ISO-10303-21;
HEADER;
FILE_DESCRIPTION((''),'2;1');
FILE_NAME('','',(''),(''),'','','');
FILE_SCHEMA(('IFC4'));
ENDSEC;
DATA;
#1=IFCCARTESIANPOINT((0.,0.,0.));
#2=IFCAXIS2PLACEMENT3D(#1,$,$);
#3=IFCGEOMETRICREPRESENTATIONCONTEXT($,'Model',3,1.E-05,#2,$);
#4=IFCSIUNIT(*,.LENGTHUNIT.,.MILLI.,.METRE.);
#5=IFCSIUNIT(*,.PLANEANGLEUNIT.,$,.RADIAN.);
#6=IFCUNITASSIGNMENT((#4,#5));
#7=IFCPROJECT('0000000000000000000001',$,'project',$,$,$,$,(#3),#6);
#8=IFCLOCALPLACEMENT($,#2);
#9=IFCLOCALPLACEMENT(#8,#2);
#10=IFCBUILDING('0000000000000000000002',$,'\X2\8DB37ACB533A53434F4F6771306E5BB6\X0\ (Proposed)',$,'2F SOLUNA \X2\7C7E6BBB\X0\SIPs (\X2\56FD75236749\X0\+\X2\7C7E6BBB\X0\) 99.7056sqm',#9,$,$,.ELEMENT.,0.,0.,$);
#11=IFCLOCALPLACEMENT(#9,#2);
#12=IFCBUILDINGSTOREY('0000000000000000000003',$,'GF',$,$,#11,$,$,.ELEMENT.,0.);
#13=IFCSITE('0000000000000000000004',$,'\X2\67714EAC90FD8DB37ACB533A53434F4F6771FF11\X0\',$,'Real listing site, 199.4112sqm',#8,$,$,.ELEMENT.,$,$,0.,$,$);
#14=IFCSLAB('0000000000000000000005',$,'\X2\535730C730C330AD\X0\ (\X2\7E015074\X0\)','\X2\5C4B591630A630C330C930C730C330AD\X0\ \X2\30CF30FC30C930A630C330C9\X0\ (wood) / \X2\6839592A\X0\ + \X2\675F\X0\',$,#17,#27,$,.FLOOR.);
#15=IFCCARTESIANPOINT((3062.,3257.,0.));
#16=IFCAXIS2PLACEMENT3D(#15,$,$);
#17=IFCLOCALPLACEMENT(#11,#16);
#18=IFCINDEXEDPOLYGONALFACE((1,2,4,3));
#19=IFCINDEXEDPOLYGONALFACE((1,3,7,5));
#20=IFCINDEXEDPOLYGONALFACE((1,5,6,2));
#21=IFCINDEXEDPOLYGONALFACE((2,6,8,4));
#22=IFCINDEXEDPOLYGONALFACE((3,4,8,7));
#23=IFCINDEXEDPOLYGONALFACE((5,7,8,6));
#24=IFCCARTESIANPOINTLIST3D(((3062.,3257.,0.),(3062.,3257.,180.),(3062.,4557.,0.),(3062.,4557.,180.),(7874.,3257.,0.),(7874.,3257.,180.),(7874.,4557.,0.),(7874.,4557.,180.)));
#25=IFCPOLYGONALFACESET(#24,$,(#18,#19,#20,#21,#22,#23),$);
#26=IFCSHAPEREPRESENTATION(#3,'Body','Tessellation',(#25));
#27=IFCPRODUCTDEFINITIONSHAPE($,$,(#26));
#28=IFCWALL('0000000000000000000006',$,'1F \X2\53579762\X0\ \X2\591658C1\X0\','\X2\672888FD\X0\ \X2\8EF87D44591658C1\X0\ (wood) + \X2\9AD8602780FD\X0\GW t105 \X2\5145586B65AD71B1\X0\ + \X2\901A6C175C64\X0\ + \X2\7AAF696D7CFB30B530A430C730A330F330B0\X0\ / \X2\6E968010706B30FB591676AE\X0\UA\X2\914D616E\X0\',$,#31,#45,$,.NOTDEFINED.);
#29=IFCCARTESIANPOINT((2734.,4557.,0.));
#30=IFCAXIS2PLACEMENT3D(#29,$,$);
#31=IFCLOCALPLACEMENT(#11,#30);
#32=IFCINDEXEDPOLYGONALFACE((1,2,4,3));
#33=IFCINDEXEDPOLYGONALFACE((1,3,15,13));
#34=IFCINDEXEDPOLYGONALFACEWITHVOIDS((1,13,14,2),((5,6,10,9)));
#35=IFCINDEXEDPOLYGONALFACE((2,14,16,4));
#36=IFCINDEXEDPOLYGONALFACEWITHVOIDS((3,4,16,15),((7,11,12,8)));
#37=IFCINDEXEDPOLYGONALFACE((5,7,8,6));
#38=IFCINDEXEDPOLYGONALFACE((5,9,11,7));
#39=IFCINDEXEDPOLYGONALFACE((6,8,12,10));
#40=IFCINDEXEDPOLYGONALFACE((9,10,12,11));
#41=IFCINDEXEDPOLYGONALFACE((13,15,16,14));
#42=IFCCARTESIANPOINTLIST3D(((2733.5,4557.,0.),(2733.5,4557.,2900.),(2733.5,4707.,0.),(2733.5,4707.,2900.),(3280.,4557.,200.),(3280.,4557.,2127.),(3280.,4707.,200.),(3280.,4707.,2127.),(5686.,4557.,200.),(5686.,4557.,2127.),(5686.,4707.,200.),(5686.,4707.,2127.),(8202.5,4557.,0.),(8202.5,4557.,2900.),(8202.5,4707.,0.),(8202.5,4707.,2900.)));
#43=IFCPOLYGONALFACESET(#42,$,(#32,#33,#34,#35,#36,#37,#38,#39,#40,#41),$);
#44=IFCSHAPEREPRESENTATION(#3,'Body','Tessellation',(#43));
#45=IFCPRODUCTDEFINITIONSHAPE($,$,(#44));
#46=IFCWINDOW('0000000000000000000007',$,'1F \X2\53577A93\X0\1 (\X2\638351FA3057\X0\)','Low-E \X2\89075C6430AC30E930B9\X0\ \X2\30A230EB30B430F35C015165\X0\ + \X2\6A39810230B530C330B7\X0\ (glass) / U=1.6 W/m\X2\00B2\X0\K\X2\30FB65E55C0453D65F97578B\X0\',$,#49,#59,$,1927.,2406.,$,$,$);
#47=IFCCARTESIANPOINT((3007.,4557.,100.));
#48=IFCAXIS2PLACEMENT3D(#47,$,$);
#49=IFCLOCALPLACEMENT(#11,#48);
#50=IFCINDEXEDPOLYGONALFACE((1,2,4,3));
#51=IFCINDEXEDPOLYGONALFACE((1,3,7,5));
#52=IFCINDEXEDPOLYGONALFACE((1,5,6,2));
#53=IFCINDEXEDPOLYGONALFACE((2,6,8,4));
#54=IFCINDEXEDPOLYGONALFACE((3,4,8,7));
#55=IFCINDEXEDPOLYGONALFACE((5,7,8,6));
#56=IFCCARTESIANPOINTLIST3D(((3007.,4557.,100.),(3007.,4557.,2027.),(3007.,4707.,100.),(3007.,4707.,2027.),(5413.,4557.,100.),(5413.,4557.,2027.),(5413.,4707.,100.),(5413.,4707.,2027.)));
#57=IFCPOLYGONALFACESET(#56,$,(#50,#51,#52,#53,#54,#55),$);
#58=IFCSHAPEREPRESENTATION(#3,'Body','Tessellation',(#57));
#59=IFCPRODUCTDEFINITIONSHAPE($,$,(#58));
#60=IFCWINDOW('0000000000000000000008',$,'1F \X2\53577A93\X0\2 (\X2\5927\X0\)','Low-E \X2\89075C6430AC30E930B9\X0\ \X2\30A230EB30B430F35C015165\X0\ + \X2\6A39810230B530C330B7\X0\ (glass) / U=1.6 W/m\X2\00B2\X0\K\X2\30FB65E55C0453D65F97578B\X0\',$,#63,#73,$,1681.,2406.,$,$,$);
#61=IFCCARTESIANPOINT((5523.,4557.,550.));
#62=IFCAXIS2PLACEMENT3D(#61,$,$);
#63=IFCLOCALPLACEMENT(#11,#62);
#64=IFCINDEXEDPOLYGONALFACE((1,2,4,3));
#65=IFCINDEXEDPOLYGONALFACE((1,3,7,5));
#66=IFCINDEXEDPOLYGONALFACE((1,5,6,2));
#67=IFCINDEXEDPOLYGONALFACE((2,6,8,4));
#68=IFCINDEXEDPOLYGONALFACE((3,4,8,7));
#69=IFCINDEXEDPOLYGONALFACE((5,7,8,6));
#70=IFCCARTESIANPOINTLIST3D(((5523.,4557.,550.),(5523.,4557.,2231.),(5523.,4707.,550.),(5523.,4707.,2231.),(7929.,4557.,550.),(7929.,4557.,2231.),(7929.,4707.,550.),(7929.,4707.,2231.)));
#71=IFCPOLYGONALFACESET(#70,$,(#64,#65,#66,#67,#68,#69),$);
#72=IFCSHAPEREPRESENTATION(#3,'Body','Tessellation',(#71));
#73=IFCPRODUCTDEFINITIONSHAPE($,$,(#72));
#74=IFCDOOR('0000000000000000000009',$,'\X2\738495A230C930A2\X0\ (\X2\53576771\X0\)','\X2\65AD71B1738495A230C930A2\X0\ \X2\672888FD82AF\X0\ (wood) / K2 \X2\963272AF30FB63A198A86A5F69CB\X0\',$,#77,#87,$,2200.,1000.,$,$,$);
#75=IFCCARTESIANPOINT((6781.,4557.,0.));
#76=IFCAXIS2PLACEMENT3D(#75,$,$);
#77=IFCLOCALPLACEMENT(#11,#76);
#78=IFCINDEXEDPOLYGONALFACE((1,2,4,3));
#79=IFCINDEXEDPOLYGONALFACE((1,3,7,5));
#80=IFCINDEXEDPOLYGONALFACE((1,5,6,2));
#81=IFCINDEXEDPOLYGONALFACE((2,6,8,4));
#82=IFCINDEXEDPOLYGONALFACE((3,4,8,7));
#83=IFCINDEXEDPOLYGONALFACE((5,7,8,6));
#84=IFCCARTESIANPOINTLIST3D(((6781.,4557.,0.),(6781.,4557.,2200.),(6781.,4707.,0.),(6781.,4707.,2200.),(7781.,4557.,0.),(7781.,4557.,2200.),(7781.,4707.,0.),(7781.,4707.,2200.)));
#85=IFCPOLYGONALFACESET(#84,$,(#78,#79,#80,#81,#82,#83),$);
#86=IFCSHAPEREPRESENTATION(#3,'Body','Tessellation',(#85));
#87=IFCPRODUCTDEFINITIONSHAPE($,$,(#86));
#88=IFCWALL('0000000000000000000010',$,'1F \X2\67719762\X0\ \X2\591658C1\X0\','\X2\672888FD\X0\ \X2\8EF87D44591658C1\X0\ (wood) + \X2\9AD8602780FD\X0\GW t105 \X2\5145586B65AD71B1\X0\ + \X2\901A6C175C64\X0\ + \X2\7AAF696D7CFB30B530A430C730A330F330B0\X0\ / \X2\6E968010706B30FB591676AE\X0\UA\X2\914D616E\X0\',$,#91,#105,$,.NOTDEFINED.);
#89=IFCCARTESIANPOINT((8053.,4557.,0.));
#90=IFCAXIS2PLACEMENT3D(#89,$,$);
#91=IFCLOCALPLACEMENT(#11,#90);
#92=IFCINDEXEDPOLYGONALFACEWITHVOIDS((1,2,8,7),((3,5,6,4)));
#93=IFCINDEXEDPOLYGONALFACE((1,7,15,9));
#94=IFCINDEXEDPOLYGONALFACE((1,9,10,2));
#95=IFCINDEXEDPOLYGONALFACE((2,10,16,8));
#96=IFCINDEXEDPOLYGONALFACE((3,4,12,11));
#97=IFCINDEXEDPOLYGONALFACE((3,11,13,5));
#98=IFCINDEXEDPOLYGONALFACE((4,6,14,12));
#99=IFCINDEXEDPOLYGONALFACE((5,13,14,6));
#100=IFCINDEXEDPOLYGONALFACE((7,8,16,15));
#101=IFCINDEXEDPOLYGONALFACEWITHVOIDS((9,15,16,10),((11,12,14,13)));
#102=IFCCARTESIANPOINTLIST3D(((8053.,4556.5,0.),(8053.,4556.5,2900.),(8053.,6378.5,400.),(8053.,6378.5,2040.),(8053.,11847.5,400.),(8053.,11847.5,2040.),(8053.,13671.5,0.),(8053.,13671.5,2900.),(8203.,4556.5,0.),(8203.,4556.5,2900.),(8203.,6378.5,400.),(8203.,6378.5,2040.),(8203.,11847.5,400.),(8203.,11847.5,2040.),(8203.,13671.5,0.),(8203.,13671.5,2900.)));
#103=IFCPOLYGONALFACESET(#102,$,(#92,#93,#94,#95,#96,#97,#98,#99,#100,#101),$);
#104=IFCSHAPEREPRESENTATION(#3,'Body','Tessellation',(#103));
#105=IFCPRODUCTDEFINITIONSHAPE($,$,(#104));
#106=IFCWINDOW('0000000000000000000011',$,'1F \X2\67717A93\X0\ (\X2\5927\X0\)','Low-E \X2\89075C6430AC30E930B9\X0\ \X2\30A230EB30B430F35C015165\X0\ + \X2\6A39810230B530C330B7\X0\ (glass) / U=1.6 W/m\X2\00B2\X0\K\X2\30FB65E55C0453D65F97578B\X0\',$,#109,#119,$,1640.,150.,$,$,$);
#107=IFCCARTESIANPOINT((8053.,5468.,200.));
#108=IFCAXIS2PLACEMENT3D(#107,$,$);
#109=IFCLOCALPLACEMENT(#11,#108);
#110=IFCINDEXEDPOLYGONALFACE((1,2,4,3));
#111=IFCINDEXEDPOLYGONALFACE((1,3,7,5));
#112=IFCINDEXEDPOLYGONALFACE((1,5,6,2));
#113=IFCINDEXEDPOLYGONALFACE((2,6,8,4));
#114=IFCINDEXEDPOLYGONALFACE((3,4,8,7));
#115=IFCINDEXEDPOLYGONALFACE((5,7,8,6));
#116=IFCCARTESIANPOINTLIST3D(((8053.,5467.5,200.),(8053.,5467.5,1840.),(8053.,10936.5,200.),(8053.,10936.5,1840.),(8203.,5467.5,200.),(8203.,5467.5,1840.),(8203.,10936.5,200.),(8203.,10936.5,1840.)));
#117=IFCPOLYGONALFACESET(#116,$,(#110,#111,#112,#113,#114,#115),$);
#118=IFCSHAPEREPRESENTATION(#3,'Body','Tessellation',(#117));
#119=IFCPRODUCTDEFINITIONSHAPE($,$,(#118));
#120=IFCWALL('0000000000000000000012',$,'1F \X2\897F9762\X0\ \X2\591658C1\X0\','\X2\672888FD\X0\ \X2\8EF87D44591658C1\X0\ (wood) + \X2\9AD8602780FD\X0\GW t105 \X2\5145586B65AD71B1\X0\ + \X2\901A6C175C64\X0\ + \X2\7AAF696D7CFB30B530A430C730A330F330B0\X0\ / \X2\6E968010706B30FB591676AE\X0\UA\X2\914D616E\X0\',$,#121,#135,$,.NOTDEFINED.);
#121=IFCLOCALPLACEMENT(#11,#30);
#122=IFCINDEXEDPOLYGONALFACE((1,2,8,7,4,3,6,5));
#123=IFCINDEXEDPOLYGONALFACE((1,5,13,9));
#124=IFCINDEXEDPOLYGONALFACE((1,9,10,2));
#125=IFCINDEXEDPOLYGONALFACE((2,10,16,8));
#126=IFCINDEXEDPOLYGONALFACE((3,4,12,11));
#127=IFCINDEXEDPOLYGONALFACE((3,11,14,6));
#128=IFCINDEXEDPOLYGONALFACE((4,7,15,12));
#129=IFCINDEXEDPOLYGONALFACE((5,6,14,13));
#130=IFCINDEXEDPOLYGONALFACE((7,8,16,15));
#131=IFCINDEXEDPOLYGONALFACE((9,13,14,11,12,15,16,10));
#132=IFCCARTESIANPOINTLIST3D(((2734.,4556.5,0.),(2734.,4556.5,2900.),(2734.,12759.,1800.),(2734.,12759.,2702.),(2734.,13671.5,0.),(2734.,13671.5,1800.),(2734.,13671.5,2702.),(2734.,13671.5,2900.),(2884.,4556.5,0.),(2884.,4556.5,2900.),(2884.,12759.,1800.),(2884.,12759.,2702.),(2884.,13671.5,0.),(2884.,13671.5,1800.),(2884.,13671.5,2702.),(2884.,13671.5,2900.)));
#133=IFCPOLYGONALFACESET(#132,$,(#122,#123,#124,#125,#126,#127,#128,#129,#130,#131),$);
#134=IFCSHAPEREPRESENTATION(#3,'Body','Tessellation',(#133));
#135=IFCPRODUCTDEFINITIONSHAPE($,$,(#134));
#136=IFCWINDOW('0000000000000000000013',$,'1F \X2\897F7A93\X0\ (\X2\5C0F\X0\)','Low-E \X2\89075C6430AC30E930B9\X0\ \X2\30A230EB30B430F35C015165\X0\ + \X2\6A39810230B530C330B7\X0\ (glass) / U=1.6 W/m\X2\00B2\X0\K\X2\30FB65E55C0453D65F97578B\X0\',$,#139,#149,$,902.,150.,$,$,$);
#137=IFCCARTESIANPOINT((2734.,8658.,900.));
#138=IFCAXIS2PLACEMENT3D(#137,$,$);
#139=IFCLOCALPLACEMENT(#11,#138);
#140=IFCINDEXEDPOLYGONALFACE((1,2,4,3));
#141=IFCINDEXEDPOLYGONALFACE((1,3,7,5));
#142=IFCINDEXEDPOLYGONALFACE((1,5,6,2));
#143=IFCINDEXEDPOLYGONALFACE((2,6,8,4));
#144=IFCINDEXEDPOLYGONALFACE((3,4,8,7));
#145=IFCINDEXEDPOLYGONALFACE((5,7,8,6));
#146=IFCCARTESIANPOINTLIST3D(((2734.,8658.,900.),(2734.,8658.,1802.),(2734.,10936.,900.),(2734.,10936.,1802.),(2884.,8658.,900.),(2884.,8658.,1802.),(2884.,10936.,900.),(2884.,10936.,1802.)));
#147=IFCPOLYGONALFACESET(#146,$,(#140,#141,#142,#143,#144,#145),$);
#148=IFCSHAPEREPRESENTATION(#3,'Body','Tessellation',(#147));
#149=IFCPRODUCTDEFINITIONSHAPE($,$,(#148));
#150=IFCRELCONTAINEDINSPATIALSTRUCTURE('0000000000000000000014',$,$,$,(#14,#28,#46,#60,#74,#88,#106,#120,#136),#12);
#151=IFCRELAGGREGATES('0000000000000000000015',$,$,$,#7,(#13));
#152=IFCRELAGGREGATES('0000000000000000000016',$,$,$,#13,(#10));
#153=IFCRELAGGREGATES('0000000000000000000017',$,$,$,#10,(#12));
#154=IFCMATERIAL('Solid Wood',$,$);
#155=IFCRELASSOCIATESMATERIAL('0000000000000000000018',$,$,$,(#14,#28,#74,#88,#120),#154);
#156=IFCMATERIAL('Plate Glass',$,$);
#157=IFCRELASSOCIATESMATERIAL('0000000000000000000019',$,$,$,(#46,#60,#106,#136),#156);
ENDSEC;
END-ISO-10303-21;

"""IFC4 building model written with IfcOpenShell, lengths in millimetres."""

from ifc_helpers import new_model, si_unit, frame, frame_2d, origin, place, context, project, spatial, rectangle, extrude, material, element, fill, save


model = new_model("IFC4")

# Units and contexts
model_context = context("Model", 3, precision=1e-05, world=origin())
ifc_project = project(units=[si_unit("LENGTHUNIT", "METRE", prefix="MILLI"), si_unit("PLANEANGLEUNIT", "RADIAN")], contexts=[model_context])

# Site, building, storey
site_placement = place(None, origin())
site = spatial("IfcSite", under=ifc_project, at=site_placement, Name="東京都足立区千住東１", ObjectType="Real listing site, 199.4112sqm", CompositionType="ELEMENT", RefElevation=0.0)
building_placement = place(site_placement, origin())
building = spatial("IfcBuilding", under=site, at=building_placement, Name="足立区千住東の家 (Proposed)", ObjectType="2F SOLUNA 籾殻SIPs (国産杉+籾殻) 99.7056sqm", CompositionType="ELEMENT", ElevationOfRefHeight=0.0, ElevationOfTerrain=0.0)
storey_placement = place(building_placement, origin())
storey = spatial("IfcBuildingStorey", under=building, at=storey_placement, Name="GF", CompositionType="ELEMENT", Elevation=0.0)

# Slab
ifc_material_1 = material(Name="Solid Wood")
slab_1_placement = place(storey_placement, frame((3062.0, 3257.0, 0.0)))
element("IfcSlab", 1, at=slab_1_placement, inside=storey, material=ifc_material_1, Name="南デッキ (縁側)", Description="屋外ウッドデッキ ハードウッド (wood) / 根太 + 束", PredefinedType="FLOOR", context=model_context, shape_type="SweptSolid", body=[
    extrude(rectangle(XDim=4812.0, YDim=1300.0, at=frame_2d((2406.0, 650.0))), frame((3062.0, 3257.0, 0.0)), (0.0, 0.0, 1.0), 180.0),
])

# Wall, openings, windows, door
wall_1_placement = place(storey_placement, frame((2734.0, 4557.0, 0.0)))
wall_1 = element("IfcWall", 2, at=wall_1_placement, inside=storey, material=ifc_material_1, Name="1F 南面 外壁", Description="木製 軸組外壁 (wood) + 高性能GW t105 充填断熱 + 通気層 + 窯業系サイディング / 準耐火・外皮UA配慮", PredefinedType="NOTDEFINED", context=model_context, shape_type="SweptSolid", body=[
    extrude(rectangle(XDim=5469.0, YDim=150.0, at=frame_2d((2734.0, 75.0))), frame((2734.0, 4557.0, 0.0)), (0.0, 0.0, 1.0), 2900.0),
])
opening_1_placement = place(storey_placement, frame((3007.0, 4557.0, 100.0)))
opening_1 = element("IfcOpeningElement", 3, at=opening_1_placement, cuts=wall_1, PredefinedType="NOTDEFINED", context=model_context, shape_type="SweptSolid", body=[
    extrude(rectangle(XDim=2406.0, YDim=150.0, at=frame_2d((1203.0, 75.0))), frame((3007.0, 4557.0, 100.0)), (0.0, 0.0, 1.0), 1927.0),
])
opening_2_placement = place(storey_placement, frame((5523.0, 4557.0, 550.0)))
opening_2 = element("IfcOpeningElement", 4, at=opening_2_placement, cuts=wall_1, PredefinedType="NOTDEFINED", context=model_context, shape_type="SweptSolid", body=[
    extrude(rectangle(XDim=2406.0, YDim=150.0, at=frame_2d((1203.0, 75.0))), frame((5523.0, 4557.0, 550.0)), (0.0, 0.0, 1.0), 1681.0),
])
opening_3_placement = place(storey_placement, frame((6781.0, 4557.0, 0.0)))
opening_3 = element("IfcOpeningElement", 5, at=opening_3_placement, cuts=wall_1, PredefinedType="NOTDEFINED", context=model_context, shape_type="SweptSolid", body=[
    extrude(rectangle(XDim=1000.0, YDim=150.0, at=frame_2d((500.0, 75.0))), frame((6781.0, 4557.0, 0.0)), (0.0, 0.0, 1.0), 2200.0),
])
ifc_material_2 = material(Name="Plate Glass")
window_1_placement = place(storey_placement, frame((3007.0, 4557.0, 100.0)))
window_1 = element("IfcWindow", 6, at=window_1_placement, inside=storey, material=ifc_material_2, Name="1F 南窓1 (掃出し)", Description="Low-E 複層ガラス アルゴン封入 + 樹脂サッシ (glass) / U=1.6 W/m²K・日射取得型", OverallHeight=1927.0, OverallWidth=2406.0, context=model_context, shape_type="SweptSolid", body=[
    extrude(rectangle(XDim=2406.0, YDim=150.0, at=frame_2d((1203.0, 75.0))), frame((3007.0, 4557.0, 100.0)), (0.0, 0.0, 1.0), 1927.0),
])
fill(opening_1, window_1)
window_2_placement = place(storey_placement, frame((5523.0, 4557.0, 550.0)))
window_2 = element("IfcWindow", 7, at=window_2_placement, inside=storey, material=ifc_material_2, Name="1F 南窓2 (大)", Description="Low-E 複層ガラス アルゴン封入 + 樹脂サッシ (glass) / U=1.6 W/m²K・日射取得型", OverallHeight=1681.0, OverallWidth=2406.0, context=model_context, shape_type="SweptSolid", body=[
    extrude(rectangle(XDim=2406.0, YDim=150.0, at=frame_2d((1203.0, 75.0))), frame((5523.0, 4557.0, 550.0)), (0.0, 0.0, 1.0), 1681.0),
])
fill(opening_2, window_2)
door_placement = place(storey_placement, frame((6781.0, 4557.0, 0.0)))
door = element("IfcDoor", 8, at=door_placement, inside=storey, material=ifc_material_1, Name="玄関ドア (南東)", Description="断熱玄関ドア 木製芯 (wood) / K2 防犯・採風機構", OverallHeight=2200.0, OverallWidth=1000.0, context=model_context, shape_type="SweptSolid", body=[
    extrude(rectangle(XDim=1000.0, YDim=150.0, at=frame_2d((500.0, 75.0))), frame((6781.0, 4557.0, 0.0)), (0.0, 0.0, 1.0), 2200.0),
])
fill(opening_3, door)

# Walls, openings, windows
wall_2_placement = place(storey_placement, frame((8053.0, 4557.0, 0.0)))
wall_2 = element("IfcWall", 9, at=wall_2_placement, inside=storey, material=ifc_material_1, Name="1F 東面 外壁", Description="木製 軸組外壁 (wood) + 高性能GW t105 充填断熱 + 通気層 + 窯業系サイディング / 準耐火・外皮UA配慮", PredefinedType="NOTDEFINED", context=model_context, shape_type="SweptSolid", body=[
    extrude(rectangle(XDim=150.0, YDim=9115.0, at=frame_2d((75.0, 4557.0))), frame((8053.0, 4557.0, 0.0)), (0.0, 0.0, 1.0), 2900.0),
])
opening_4_placement = place(storey_placement, frame((8053.0, 5468.0, 200.0)))
opening_4 = element("IfcOpeningElement", 10, at=opening_4_placement, cuts=wall_2, PredefinedType="NOTDEFINED", context=model_context, shape_type="SweptSolid", body=[
    extrude(rectangle(XDim=150.0, YDim=5469.0, at=frame_2d((75.0, 2734.0))), frame((8053.0, 5468.0, 200.0)), (0.0, 0.0, 1.0), 1640.0),
])
window_3_placement = place(storey_placement, frame((8053.0, 5468.0, 200.0)))
window_3 = element("IfcWindow", 11, at=window_3_placement, inside=storey, material=ifc_material_2, Name="1F 東窓 (大)", Description="Low-E 複層ガラス アルゴン封入 + 樹脂サッシ (glass) / U=1.6 W/m²K・日射取得型", OverallHeight=1640.0, OverallWidth=150.0, context=model_context, shape_type="SweptSolid", body=[
    extrude(rectangle(XDim=150.0, YDim=5469.0, at=frame_2d((75.0, 2734.0))), frame((8053.0, 5468.0, 200.0)), (0.0, 0.0, 1.0), 1640.0),
])
fill(opening_4, window_3)
wall_3_placement = place(storey_placement, frame((2734.0, 4557.0, 0.0)))
wall_3 = element("IfcWall", 12, at=wall_3_placement, inside=storey, material=ifc_material_1, Name="1F 西面 外壁", Description="木製 軸組外壁 (wood) + 高性能GW t105 充填断熱 + 通気層 + 窯業系サイディング / 準耐火・外皮UA配慮", PredefinedType="NOTDEFINED", context=model_context, shape_type="SweptSolid", body=[
    extrude(rectangle(XDim=150.0, YDim=9115.0, at=frame_2d((75.0, 4557.0))), frame((2734.0, 4557.0, 0.0)), (0.0, 0.0, 1.0), 2900.0),
])
opening_5_placement = place(storey_placement, frame((2734.0, 8658.0, 900.0)))
opening_5 = element("IfcOpeningElement", 13, at=opening_5_placement, cuts=wall_3, PredefinedType="NOTDEFINED", context=model_context, shape_type="SweptSolid", body=[
    extrude(rectangle(XDim=150.0, YDim=2278.0, at=frame_2d((75.0, 1139.0))), frame((2734.0, 8658.0, 900.0)), (0.0, 0.0, 1.0), 902.0),
])
window_4_placement = place(storey_placement, frame((2734.0, 8658.0, 900.0)))
window_4 = element("IfcWindow", 14, at=window_4_placement, inside=storey, material=ifc_material_2, Name="1F 西窓 (小)", Description="Low-E 複層ガラス アルゴン封入 + 樹脂サッシ (glass) / U=1.6 W/m²K・日射取得型", OverallHeight=902.0, OverallWidth=150.0, context=model_context, shape_type="SweptSolid", body=[
    extrude(rectangle(XDim=150.0, YDim=2278.0, at=frame_2d((75.0, 1139.0))), frame((2734.0, 8658.0, 900.0)), (0.0, 0.0, 1.0), 902.0),
])
fill(opening_5, window_4)

save(model, "model.ifc")
